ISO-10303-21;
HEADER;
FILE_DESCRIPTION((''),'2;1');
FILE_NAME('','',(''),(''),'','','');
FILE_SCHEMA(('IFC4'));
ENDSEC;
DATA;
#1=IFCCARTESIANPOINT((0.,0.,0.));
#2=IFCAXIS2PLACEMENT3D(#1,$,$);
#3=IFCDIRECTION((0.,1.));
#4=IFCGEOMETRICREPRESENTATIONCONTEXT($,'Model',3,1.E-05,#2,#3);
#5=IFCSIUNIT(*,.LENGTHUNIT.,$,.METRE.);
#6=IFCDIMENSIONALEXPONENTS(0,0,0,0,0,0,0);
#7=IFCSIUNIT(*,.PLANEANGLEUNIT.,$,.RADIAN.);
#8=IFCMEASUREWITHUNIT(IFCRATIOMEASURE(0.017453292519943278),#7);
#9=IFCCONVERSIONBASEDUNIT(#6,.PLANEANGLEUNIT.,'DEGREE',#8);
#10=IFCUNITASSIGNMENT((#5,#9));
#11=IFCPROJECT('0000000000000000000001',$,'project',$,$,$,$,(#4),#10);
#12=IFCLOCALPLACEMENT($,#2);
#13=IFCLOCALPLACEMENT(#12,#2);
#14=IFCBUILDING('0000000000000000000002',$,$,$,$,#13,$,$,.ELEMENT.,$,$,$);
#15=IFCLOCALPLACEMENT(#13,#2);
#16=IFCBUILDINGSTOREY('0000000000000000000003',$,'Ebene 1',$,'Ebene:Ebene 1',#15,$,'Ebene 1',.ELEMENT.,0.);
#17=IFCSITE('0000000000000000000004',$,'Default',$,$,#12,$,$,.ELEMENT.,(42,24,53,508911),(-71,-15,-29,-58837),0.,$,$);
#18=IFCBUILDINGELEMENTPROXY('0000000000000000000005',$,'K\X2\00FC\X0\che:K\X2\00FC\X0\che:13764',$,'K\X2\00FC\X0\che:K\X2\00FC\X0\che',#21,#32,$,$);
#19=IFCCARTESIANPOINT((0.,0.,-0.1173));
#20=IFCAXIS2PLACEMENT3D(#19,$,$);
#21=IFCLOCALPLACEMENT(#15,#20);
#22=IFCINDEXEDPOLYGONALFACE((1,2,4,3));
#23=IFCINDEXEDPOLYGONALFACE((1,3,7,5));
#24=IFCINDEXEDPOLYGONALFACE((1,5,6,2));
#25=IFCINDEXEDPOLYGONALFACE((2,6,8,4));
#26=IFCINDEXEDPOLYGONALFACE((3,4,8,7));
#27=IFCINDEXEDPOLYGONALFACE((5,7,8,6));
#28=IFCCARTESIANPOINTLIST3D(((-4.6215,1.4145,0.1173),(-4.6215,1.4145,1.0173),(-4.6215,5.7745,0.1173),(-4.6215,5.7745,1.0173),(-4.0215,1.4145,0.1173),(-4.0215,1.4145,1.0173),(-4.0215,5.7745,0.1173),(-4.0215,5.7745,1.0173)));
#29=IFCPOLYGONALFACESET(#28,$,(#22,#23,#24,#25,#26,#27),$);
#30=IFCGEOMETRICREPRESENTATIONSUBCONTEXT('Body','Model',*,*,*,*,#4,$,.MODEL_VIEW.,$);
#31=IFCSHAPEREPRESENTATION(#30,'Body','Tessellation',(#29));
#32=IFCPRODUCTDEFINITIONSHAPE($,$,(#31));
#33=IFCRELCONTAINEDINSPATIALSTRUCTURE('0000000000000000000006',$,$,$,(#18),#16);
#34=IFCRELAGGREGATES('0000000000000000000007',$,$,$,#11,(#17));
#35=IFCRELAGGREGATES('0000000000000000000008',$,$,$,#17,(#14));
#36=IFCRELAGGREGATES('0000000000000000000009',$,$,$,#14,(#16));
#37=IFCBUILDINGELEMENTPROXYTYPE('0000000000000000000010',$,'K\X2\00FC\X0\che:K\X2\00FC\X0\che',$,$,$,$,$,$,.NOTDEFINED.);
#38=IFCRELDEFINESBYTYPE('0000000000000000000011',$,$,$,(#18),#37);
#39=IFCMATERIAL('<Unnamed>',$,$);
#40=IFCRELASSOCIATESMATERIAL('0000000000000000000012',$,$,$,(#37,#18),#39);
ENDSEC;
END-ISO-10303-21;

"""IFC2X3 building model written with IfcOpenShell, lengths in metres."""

from ifc_helpers import new_model, entity, si_unit, converted_unit, direction, frame, frame_2d, origin, place, context, subcontext, project, spatial, rectangle, extrude, source, transform, mapped, material, type_object, type_shapes, element, save


model = new_model("IFC2X3")

# Units and contexts
model_context = context("Model", 3, precision=1e-05, world=origin(), true_north=direction((0.0, 1.0)))
body_context = subcontext(model_context, "Body", "Model", "MODEL_VIEW")
ifc_project = project(units=[si_unit("LENGTHUNIT", "METRE"), converted_unit("PLANEANGLEUNIT", "DEGREE", entity("IfcRatioMeasure", 0.017453292519943278), si_unit("PLANEANGLEUNIT", "RADIAN"), dimensions=[0, 0, 0, 0, 0, 0, 0])], contexts=[model_context])

# Site, building, storey
site_placement = place(None, origin())
site = spatial("IfcSite", under=ifc_project, at=site_placement, Name="Default", CompositionType="ELEMENT", RefLatitude=(42, 24, 53, 508911), RefLongitude=(-71, -15, -29, -58837), RefElevation=0.0)
building_placement = place(site_placement, origin())
building = spatial("IfcBuilding", under=site, at=building_placement, CompositionType="ELEMENT")
storey_placement = place(building_placement, origin())
storey = spatial("IfcBuildingStorey", under=building, at=storey_placement, Name="Ebene 1", ObjectType="Ebene:Ebene 1", LongName="Ebene 1", CompositionType="ELEMENT", Elevation=0.0)

# Shared definitions
ifc_material_1 = material(Name="<Unnamed>")

# Building element proxy
building_element_proxy_type = type_object("IfcBuildingElementProxyType", Name="Küche:Küche", PredefinedType="NOTDEFINED", material=ifc_material_1)
shared_shape = source(origin(), body_context, "Body", "SweptSolid", [
    extrude(rectangle(XDim=0.9, YDim=4.36, at=frame_2d((0.0, 0.0), x_axis=(1.0, 0.0))), frame((-4.6215, 3.5945, 0.5673), z_axis=(1.0, 0.0, 0.0), x_axis=(0.0, 0.0, 1.0)), (0.0, 0.0, 1.0), 0.6),
])
type_shapes(building_element_proxy_type, [shared_shape])
proxy_placement = place(storey_placement, frame((0.0, 0.0, -0.1173)))
element("IfcBuildingElementProxy", 1, at=proxy_placement, inside=storey, type_object=building_element_proxy_type, material=ifc_material_1, Name="Küche:Küche:13764", ObjectType="Küche:Küche", context=body_context, shape_type="MappedRepresentation", body=[
    mapped(shared_shape, transform((0.0, 0.0, 0.0), scale=1.0)),
])

save(model, "model.ifc")
